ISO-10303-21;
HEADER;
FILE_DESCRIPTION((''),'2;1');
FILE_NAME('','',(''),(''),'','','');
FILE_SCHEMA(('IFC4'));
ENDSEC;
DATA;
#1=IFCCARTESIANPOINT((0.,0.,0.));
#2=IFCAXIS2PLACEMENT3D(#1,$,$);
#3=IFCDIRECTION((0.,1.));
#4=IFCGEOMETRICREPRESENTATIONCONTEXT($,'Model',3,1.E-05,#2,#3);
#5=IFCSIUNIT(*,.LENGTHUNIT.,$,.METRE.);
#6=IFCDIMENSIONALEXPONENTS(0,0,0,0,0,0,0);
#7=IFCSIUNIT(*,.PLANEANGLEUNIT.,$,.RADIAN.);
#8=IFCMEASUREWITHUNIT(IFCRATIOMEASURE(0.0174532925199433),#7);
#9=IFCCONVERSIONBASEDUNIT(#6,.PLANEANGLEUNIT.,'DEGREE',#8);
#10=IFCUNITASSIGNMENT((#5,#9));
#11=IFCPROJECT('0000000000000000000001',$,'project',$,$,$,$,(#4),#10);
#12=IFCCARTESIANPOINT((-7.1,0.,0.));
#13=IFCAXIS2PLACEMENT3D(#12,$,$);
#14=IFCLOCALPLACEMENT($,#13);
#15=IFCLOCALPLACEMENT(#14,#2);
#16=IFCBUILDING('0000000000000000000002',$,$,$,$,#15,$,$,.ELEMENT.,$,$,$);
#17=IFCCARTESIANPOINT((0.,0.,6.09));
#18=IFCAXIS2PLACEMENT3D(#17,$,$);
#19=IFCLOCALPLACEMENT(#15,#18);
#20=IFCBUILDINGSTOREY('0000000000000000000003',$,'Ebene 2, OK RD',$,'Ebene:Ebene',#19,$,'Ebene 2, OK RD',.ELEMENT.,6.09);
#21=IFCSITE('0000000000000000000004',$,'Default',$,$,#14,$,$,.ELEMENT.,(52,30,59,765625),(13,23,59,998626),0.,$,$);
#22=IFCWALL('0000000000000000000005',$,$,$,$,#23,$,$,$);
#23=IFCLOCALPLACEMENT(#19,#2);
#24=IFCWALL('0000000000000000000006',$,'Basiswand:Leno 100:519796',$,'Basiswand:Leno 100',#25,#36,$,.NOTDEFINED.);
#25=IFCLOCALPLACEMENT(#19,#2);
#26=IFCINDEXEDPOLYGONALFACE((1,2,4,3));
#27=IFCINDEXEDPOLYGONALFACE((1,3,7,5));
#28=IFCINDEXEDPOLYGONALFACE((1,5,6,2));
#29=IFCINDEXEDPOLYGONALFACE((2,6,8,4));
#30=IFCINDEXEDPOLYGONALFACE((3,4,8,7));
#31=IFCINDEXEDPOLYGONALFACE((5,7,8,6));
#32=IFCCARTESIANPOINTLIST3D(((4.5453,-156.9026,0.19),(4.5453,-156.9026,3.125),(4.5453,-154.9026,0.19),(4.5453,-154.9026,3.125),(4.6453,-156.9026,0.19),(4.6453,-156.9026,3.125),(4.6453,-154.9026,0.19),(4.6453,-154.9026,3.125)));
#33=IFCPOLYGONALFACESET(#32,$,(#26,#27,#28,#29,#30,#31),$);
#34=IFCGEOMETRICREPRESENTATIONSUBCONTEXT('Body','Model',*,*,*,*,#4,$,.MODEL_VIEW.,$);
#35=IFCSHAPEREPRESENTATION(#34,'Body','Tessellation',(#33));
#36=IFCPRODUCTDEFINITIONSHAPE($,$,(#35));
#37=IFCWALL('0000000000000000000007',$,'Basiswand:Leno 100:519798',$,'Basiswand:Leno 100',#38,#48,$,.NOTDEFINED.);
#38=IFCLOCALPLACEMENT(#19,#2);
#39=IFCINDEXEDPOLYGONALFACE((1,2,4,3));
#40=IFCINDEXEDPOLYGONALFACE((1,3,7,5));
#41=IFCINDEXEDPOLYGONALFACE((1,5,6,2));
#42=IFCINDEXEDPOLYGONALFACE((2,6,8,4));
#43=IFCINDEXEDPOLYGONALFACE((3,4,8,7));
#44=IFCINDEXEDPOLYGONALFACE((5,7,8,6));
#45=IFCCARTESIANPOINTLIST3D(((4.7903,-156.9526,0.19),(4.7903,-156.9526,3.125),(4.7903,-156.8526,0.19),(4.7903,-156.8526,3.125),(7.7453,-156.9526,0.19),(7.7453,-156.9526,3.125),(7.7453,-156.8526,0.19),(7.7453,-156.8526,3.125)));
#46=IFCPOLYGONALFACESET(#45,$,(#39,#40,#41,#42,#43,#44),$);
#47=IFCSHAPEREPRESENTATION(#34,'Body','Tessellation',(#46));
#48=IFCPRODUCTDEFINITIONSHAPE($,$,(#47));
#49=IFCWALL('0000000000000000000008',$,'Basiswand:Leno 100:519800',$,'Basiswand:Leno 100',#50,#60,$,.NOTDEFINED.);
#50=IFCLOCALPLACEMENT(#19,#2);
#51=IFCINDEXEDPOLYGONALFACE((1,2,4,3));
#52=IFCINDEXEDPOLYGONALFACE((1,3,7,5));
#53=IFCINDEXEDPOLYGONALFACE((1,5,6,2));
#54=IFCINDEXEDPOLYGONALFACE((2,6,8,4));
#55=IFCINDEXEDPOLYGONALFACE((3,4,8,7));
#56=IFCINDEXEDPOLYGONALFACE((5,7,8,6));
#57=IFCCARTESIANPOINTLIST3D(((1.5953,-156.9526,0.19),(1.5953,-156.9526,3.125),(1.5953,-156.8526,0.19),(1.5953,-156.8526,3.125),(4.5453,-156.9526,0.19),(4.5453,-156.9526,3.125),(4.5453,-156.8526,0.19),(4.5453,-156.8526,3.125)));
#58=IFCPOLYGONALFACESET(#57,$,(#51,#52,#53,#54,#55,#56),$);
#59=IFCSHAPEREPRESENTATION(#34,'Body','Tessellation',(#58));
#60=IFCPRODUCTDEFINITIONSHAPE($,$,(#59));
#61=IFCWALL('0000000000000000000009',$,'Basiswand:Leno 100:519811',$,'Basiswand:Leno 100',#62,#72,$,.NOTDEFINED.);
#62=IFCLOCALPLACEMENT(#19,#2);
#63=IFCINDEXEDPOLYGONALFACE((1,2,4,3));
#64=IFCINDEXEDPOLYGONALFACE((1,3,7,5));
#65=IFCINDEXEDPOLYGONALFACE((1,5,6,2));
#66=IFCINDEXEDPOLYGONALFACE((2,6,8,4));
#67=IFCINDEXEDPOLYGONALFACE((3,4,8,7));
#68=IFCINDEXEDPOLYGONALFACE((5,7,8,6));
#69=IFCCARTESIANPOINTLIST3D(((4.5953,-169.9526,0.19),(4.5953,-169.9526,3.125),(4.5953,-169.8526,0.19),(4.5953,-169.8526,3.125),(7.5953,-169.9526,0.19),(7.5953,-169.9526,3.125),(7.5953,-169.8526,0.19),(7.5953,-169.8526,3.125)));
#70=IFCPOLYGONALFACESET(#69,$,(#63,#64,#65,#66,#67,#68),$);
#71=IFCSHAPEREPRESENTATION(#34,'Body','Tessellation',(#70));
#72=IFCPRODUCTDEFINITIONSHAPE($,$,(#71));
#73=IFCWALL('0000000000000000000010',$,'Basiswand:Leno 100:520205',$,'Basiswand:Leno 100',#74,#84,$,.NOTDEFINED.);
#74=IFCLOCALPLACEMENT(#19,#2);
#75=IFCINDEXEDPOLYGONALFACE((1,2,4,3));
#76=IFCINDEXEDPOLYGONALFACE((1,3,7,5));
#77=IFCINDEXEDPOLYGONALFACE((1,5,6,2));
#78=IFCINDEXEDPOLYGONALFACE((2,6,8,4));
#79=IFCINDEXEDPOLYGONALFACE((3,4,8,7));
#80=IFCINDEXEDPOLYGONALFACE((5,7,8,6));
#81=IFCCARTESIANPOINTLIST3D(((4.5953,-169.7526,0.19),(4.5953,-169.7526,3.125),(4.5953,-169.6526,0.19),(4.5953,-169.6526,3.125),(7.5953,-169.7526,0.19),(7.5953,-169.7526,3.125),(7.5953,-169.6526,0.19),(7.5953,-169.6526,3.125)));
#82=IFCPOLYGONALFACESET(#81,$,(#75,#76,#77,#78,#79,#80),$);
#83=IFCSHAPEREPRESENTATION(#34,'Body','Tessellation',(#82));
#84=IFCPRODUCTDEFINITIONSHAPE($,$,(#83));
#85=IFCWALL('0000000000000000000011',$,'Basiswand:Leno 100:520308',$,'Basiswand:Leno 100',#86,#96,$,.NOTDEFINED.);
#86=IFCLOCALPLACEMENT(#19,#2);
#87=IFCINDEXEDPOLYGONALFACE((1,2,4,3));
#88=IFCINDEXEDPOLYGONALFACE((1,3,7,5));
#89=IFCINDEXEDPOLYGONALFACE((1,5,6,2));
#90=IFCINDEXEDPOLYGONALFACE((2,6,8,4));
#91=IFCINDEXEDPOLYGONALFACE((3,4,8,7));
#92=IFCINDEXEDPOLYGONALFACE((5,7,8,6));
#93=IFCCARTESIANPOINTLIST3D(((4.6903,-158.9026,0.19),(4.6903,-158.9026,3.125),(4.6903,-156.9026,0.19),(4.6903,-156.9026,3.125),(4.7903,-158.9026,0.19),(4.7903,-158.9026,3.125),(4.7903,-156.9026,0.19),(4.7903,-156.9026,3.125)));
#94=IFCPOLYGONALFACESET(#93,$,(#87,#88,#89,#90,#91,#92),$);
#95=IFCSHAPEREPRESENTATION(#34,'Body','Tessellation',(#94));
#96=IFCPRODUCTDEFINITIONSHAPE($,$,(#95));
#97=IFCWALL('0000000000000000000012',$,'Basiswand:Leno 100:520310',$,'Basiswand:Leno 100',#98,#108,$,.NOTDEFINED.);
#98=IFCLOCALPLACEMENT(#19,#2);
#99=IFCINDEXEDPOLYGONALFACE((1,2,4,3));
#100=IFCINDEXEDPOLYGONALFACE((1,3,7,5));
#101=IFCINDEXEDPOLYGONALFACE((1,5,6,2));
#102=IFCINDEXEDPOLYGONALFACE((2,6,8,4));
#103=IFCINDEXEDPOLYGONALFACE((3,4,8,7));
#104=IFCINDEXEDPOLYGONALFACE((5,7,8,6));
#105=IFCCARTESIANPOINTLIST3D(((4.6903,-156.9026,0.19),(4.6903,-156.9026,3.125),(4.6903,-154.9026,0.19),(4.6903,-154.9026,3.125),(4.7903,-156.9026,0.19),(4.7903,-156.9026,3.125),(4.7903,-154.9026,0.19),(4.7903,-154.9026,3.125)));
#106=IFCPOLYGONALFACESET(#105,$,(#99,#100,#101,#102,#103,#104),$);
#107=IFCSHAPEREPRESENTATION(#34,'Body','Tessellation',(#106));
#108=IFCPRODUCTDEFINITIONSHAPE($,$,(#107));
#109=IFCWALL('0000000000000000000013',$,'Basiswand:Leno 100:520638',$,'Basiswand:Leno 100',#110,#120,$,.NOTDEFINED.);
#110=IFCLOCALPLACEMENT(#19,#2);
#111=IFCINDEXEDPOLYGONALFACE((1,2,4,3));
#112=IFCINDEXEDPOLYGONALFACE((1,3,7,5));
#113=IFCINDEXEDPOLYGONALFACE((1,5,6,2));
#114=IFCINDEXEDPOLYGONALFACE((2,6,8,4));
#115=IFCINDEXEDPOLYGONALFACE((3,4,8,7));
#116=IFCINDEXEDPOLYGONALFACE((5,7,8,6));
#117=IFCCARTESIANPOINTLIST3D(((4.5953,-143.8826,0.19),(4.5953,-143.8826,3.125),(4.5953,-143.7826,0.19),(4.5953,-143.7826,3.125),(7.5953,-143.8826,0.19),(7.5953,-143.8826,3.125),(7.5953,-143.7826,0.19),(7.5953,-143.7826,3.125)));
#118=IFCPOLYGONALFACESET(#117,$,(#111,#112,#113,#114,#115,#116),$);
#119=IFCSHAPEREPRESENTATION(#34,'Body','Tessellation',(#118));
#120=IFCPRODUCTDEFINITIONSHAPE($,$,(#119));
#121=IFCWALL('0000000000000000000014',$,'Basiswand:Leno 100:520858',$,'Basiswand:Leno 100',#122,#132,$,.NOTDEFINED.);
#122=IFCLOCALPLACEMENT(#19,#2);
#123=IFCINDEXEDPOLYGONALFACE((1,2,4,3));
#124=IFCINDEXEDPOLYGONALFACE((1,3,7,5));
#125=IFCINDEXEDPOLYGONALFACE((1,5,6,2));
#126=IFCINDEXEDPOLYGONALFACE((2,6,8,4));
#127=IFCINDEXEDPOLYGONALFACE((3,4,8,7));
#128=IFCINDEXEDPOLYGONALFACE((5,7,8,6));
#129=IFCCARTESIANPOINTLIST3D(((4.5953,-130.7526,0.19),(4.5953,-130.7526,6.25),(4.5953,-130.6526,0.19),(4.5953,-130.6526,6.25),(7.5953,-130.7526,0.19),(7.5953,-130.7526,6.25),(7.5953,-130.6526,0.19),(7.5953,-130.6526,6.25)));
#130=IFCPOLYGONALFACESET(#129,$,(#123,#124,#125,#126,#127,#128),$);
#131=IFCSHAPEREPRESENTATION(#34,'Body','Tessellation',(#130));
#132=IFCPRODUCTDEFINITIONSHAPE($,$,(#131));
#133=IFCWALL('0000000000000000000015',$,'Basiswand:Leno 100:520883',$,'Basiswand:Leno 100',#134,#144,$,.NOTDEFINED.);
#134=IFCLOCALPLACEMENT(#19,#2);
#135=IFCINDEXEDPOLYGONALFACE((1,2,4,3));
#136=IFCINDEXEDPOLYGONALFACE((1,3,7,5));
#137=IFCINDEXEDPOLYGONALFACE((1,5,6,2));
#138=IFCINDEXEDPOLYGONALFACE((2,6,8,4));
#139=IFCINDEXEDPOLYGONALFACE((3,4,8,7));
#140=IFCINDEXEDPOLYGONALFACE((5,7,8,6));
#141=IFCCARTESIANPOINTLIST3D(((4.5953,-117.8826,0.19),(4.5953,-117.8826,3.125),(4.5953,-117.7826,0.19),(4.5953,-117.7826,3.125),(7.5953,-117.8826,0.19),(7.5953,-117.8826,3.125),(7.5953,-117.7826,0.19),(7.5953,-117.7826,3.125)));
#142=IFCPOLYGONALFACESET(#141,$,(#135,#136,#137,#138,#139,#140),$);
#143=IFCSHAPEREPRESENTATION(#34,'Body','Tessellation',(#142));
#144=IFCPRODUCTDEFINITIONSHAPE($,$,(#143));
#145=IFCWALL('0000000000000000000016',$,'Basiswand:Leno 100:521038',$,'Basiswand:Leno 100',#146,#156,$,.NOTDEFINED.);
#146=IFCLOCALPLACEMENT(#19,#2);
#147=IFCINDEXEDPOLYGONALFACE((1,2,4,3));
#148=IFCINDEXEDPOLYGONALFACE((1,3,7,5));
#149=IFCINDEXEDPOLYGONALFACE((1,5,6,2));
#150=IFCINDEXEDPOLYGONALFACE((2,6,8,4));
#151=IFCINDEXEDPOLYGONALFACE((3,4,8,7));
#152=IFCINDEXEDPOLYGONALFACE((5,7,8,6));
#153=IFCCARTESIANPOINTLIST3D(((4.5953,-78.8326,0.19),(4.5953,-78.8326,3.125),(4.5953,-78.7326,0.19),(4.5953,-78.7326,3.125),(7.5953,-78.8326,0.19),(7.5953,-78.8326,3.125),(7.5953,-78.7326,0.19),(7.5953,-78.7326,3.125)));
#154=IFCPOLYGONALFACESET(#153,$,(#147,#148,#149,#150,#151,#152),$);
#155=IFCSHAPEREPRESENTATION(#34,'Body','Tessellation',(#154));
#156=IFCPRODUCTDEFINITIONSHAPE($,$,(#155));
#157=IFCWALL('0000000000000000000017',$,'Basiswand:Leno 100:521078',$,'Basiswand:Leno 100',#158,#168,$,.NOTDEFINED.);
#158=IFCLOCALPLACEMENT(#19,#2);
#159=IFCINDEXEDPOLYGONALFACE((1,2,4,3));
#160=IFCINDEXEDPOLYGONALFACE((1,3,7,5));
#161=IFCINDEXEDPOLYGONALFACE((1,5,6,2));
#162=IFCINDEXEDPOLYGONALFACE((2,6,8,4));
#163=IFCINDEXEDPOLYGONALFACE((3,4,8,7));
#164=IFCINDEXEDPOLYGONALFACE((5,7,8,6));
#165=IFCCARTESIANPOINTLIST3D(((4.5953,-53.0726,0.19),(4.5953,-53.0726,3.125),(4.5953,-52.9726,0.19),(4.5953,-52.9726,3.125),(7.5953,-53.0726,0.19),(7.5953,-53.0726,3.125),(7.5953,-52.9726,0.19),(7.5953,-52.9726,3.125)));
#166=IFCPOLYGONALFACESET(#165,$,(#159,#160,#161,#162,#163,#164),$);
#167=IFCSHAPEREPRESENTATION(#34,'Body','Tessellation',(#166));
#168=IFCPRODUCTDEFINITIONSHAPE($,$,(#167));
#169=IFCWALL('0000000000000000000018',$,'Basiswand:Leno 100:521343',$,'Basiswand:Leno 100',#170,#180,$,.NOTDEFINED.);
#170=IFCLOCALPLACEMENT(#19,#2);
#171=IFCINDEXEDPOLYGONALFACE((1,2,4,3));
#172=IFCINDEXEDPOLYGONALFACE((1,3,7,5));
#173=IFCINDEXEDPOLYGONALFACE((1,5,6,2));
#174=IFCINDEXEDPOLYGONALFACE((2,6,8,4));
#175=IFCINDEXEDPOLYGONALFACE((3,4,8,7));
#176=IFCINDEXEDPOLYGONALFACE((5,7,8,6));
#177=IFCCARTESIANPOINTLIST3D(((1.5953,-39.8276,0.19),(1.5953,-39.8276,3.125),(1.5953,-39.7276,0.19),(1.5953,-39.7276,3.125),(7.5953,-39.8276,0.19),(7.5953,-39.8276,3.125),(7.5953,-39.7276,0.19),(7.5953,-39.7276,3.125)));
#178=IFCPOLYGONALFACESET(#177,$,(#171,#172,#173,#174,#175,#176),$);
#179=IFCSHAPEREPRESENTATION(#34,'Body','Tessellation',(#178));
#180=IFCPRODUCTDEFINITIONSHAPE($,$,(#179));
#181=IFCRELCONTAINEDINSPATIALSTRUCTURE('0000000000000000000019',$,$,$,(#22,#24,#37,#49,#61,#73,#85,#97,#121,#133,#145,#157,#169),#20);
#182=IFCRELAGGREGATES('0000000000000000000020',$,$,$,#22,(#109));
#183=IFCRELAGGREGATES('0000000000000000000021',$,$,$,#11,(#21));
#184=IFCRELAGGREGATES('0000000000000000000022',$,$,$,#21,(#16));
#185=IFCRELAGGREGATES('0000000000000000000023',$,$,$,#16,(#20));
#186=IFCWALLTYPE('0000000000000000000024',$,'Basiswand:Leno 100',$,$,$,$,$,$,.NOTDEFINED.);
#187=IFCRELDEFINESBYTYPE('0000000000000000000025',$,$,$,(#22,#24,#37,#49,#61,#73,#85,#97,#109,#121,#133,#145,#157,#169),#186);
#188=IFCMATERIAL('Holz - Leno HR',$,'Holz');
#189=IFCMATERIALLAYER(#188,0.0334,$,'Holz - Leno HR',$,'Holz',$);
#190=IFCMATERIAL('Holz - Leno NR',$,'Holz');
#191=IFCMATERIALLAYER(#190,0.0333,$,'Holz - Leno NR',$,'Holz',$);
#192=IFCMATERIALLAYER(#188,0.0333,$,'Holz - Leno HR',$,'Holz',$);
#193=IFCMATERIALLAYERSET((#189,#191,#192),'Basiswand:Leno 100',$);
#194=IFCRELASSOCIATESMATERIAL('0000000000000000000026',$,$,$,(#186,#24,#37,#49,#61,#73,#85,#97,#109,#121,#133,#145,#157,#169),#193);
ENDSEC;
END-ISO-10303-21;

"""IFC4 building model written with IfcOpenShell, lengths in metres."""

from ifc_helpers import new_model, entity, si_unit, converted_unit, direction, frame, origin, place, context, subcontext, project, spatial, indexed_curve, outline, extrude, material, layer, layer_set, type_object, element, aggregate, save


model = new_model("IFC4")

# Units and contexts
model_context = context("Model", 3, precision=1e-05, world=origin(), true_north=direction((0.0, 1.0)))
body_context = subcontext(model_context, "Body", "Model", "MODEL_VIEW")
ifc_project = project(units=[si_unit("LENGTHUNIT", "METRE"), converted_unit("PLANEANGLEUNIT", "DEGREE", entity("IfcRatioMeasure", 0.0174532925199433), si_unit("PLANEANGLEUNIT", "RADIAN"), dimensions=[0, 0, 0, 0, 0, 0, 0])], contexts=[model_context])

# Site, building, storey
site_placement = place(None, frame((-7.1, 0.0, 0.0)))
site = spatial("IfcSite", under=ifc_project, at=site_placement, Name="Default", CompositionType="ELEMENT", RefLatitude=(52, 30, 59, 765625), RefLongitude=(13, 23, 59, 998626), RefElevation=0.0)
building_placement = place(site_placement, origin())
building = spatial("IfcBuilding", under=site, at=building_placement, CompositionType="ELEMENT")
storey_placement = place(building_placement, frame((0.0, 0.0, 6.09)))
storey = spatial("IfcBuildingStorey", under=building, at=storey_placement, Name="Ebene 2, OK RD", ObjectType="Ebene:Ebene", LongName="Ebene 2, OK RD", CompositionType="ELEMENT", Elevation=6.09)

# Walls
ifc_material_1 = material(Name="Holz - Leno HR", Category="Holz")
ifc_layer_1 = layer(ifc_material_1, 0.0334, Name="Holz - Leno HR", Category="Holz")
ifc_material_2 = material(Name="Holz - Leno NR", Category="Holz")
ifc_layer_2 = layer(ifc_material_2, 0.0333, Name="Holz - Leno NR", Category="Holz")
ifc_layer_3 = layer(ifc_material_1, 0.0333, Name="Holz - Leno HR", Category="Holz")
ifc_layer_set = layer_set([ifc_layer_1, ifc_layer_2, ifc_layer_3], Name="Basiswand:Leno 100")
wall_type = type_object("IfcWallType", Name="Basiswand:Leno 100", PredefinedType="NOTDEFINED", material=ifc_layer_set)
wall_1 = element("IfcWall", 1, inside=storey, type_object=wall_type)
wall_2_placement = place(storey_placement, frame((4.5953, -154.9026, 0.19), z_axis=(0.0, 0.0, 1.0), x_axis=(0.0, -1.0, 0.0)))
element("IfcWall", 2, at=wall_2_placement, inside=storey, type_object=wall_type, material=ifc_layer_set, Name="Basiswand:Leno 100:519796", ObjectType="Basiswand:Leno 100", PredefinedType="NOTDEFINED", context=body_context, shape_type="SweptSolid", body=[
    extrude(outline(indexed_curve([(2.0, 0.05), (0.0, 0.05), (0.0, -0.05), (2.0, -0.05), (2.0, 0.05)], self_intersect=False)), origin(), (0.0, 0.0, 1.0), 2.935),
])
wall_3_placement = place(storey_placement, frame((7.7453, -156.9026, 0.19), z_axis=(0.0, 0.0, 1.0), x_axis=(-1.0, 0.0, 0.0)))
element("IfcWall", 3, at=wall_3_placement, inside=storey, type_object=wall_type, material=ifc_layer_set, Name="Basiswand:Leno 100:519798", ObjectType="Basiswand:Leno 100", PredefinedType="NOTDEFINED", context=body_context, shape_type="SweptSolid", body=[
    extrude(outline(indexed_curve([(2.955, 0.05), (0.0, 0.05), (0.0, -0.05), (2.955, -0.05), (2.955, 0.05)], self_intersect=False)), origin(), (0.0, 0.0, 1.0), 2.935),
])
wall_4_placement = place(storey_placement, frame((1.5953, -156.9026, 0.19)))
element("IfcWall", 4, at=wall_4_placement, inside=storey, type_object=wall_type, material=ifc_layer_set, Name="Basiswand:Leno 100:519800", ObjectType="Basiswand:Leno 100", PredefinedType="NOTDEFINED", context=body_context, shape_type="SweptSolid", body=[
    extrude(outline(indexed_curve([(2.95, 0.05), (0.0, 0.05), (0.0, -0.05), (2.95, -0.05), (2.95, 0.05)], self_intersect=False)), origin(), (0.0, 0.0, 1.0), 2.935),
])
for number, where, z_axis, x_axis, name in (
    (5, (7.5953, -169.9026, 0.19), (0.0, 0.0, 1.0), (-1.0, 0.0, 0.0), "Basiswand:Leno 100:519811"),
    (6, (7.5953, -169.7026, 0.19), (0.0, 0.0, 1.0), (-1.0, 0.0, 0.0), "Basiswand:Leno 100:520205"),
):
    element("IfcWall", number, at=place(storey_placement, frame(where, z_axis=z_axis, x_axis=x_axis)), inside=storey, type_object=wall_type, material=ifc_layer_set, Name=name, ObjectType="Basiswand:Leno 100", PredefinedType="NOTDEFINED", context=body_context, shape_type="SweptSolid", body=[
        extrude(outline(indexed_curve([(3.0, 0.05), (0.0, 0.05), (0.0, -0.05), (3.0, -0.05), (3.0, 0.05)], self_intersect=False)), origin(), (0.0, 0.0, 1.0), 2.935),
    ])
wall_5_placement = place(storey_placement, frame((4.7403, -158.9026, 0.19), z_axis=(0.0, 0.0, 1.0), x_axis=(0.0, 1.0, 0.0)))
element("IfcWall", 7, at=wall_5_placement, inside=storey, type_object=wall_type, material=ifc_layer_set, Name="Basiswand:Leno 100:520308", ObjectType="Basiswand:Leno 100", PredefinedType="NOTDEFINED", context=body_context, shape_type="SweptSolid", body=[
    extrude(outline(indexed_curve([(2.0, 0.05), (0.0, 0.05), (0.0, -0.05), (2.0, -0.05), (2.0, 0.05)], self_intersect=False)), origin(), (0.0, 0.0, 1.0), 2.935),
])
wall_6_placement = place(storey_placement, frame((4.7403, -154.9026, 0.19), z_axis=(0.0, 0.0, 1.0), x_axis=(0.0, -1.0, 0.0)))
element("IfcWall", 8, at=wall_6_placement, inside=storey, type_object=wall_type, material=ifc_layer_set, Name="Basiswand:Leno 100:520310", ObjectType="Basiswand:Leno 100", PredefinedType="NOTDEFINED", context=body_context, shape_type="SweptSolid", body=[
    extrude(outline(indexed_curve([(2.0, 0.05), (0.0, 0.05), (0.0, -0.05), (2.0, -0.05), (2.0, 0.05)], self_intersect=False)), origin(), (0.0, 0.0, 1.0), 2.935),
])

# Wall
wall_7_placement = place(storey_placement, frame((7.5953, -143.8326, 0.19), z_axis=(0.0, 0.0, 1.0), x_axis=(-1.0, 0.0, 0.0)))
wall_7 = element("IfcWall", 9, at=wall_7_placement, type_object=wall_type, material=ifc_layer_set, Name="Basiswand:Leno 100:520638", ObjectType="Basiswand:Leno 100", PredefinedType="NOTDEFINED", context=body_context, shape_type="SweptSolid", body=[
    extrude(outline(indexed_curve([(3.0, 0.05), (0.0, 0.05), (0.0, -0.05), (3.0, -0.05), (3.0, 0.05)], self_intersect=False)), origin(), (0.0, 0.0, 1.0), 2.935),
])
aggregate(wall_1, [wall_7])

# Walls
wall_8_placement = place(storey_placement, frame((7.5953, -130.7026, 0.19), z_axis=(0.0, 0.0, 1.0), x_axis=(-1.0, 0.0, 0.0)))
element("IfcWall", 10, at=wall_8_placement, inside=storey, type_object=wall_type, material=ifc_layer_set, Name="Basiswand:Leno 100:520858", ObjectType="Basiswand:Leno 100", PredefinedType="NOTDEFINED", context=body_context, shape_type="SweptSolid", body=[
    extrude(outline(indexed_curve([(3.0, 0.05), (0.0, 0.05), (0.0, -0.05), (3.0, -0.05), (3.0, 0.05)], self_intersect=False)), origin(), (0.0, 0.0, 1.0), 6.06),
])
for number, where, z_axis, x_axis, name in (
    (11, (7.5953, -117.8326, 0.19), (0.0, 0.0, 1.0), (-1.0, 0.0, 0.0), "Basiswand:Leno 100:520883"),
    (12, (7.5953, -78.7826, 0.19), (0.0, 0.0, 1.0), (-1.0, 0.0, 0.0), "Basiswand:Leno 100:521038"),
):
    element("IfcWall", number, at=place(storey_placement, frame(where, z_axis=z_axis, x_axis=x_axis)), inside=storey, type_object=wall_type, material=ifc_layer_set, Name=name, ObjectType="Basiswand:Leno 100", PredefinedType="NOTDEFINED", context=body_context, shape_type="SweptSolid", body=[
        extrude(outline(indexed_curve([(3.0, 0.05), (0.0, 0.05), (0.0, -0.05), (3.0, -0.05), (3.0, 0.05)], self_intersect=False)), origin(), (0.0, 0.0, 1.0), 2.935),
    ])
wall_9_placement = place(storey_placement, frame((7.5953, -53.0226, 0.19), z_axis=(0.0, 0.0, 1.0), x_axis=(-1.0, 0.0, 0.0)))
element("IfcWall", 13, at=wall_9_placement, inside=storey, type_object=wall_type, material=ifc_layer_set, Name="Basiswand:Leno 100:521078", ObjectType="Basiswand:Leno 100", PredefinedType="NOTDEFINED", context=body_context, shape_type="SweptSolid", body=[
    extrude(outline(indexed_curve([(3.0, 0.05), (0.0, 0.05), (0.0, -0.05), (3.0, -0.05), (3.0, 0.05)], self_intersect=False)), origin(), (0.0, 0.0, 1.0), 2.935),
])
wall_10_placement = place(storey_placement, frame((1.5953, -39.7776, 0.19)))
element("IfcWall", 14, at=wall_10_placement, inside=storey, type_object=wall_type, material=ifc_layer_set, Name="Basiswand:Leno 100:521343", ObjectType="Basiswand:Leno 100", PredefinedType="NOTDEFINED", context=body_context, shape_type="SweptSolid", body=[
    extrude(outline(indexed_curve([(6.0, 0.05), (0.0, 0.05), (0.0, -0.05), (6.0, -0.05), (6.0, 0.05)], self_intersect=False)), origin(), (0.0, 0.0, 1.0), 2.935),
])

save(model, "model.ifc")
